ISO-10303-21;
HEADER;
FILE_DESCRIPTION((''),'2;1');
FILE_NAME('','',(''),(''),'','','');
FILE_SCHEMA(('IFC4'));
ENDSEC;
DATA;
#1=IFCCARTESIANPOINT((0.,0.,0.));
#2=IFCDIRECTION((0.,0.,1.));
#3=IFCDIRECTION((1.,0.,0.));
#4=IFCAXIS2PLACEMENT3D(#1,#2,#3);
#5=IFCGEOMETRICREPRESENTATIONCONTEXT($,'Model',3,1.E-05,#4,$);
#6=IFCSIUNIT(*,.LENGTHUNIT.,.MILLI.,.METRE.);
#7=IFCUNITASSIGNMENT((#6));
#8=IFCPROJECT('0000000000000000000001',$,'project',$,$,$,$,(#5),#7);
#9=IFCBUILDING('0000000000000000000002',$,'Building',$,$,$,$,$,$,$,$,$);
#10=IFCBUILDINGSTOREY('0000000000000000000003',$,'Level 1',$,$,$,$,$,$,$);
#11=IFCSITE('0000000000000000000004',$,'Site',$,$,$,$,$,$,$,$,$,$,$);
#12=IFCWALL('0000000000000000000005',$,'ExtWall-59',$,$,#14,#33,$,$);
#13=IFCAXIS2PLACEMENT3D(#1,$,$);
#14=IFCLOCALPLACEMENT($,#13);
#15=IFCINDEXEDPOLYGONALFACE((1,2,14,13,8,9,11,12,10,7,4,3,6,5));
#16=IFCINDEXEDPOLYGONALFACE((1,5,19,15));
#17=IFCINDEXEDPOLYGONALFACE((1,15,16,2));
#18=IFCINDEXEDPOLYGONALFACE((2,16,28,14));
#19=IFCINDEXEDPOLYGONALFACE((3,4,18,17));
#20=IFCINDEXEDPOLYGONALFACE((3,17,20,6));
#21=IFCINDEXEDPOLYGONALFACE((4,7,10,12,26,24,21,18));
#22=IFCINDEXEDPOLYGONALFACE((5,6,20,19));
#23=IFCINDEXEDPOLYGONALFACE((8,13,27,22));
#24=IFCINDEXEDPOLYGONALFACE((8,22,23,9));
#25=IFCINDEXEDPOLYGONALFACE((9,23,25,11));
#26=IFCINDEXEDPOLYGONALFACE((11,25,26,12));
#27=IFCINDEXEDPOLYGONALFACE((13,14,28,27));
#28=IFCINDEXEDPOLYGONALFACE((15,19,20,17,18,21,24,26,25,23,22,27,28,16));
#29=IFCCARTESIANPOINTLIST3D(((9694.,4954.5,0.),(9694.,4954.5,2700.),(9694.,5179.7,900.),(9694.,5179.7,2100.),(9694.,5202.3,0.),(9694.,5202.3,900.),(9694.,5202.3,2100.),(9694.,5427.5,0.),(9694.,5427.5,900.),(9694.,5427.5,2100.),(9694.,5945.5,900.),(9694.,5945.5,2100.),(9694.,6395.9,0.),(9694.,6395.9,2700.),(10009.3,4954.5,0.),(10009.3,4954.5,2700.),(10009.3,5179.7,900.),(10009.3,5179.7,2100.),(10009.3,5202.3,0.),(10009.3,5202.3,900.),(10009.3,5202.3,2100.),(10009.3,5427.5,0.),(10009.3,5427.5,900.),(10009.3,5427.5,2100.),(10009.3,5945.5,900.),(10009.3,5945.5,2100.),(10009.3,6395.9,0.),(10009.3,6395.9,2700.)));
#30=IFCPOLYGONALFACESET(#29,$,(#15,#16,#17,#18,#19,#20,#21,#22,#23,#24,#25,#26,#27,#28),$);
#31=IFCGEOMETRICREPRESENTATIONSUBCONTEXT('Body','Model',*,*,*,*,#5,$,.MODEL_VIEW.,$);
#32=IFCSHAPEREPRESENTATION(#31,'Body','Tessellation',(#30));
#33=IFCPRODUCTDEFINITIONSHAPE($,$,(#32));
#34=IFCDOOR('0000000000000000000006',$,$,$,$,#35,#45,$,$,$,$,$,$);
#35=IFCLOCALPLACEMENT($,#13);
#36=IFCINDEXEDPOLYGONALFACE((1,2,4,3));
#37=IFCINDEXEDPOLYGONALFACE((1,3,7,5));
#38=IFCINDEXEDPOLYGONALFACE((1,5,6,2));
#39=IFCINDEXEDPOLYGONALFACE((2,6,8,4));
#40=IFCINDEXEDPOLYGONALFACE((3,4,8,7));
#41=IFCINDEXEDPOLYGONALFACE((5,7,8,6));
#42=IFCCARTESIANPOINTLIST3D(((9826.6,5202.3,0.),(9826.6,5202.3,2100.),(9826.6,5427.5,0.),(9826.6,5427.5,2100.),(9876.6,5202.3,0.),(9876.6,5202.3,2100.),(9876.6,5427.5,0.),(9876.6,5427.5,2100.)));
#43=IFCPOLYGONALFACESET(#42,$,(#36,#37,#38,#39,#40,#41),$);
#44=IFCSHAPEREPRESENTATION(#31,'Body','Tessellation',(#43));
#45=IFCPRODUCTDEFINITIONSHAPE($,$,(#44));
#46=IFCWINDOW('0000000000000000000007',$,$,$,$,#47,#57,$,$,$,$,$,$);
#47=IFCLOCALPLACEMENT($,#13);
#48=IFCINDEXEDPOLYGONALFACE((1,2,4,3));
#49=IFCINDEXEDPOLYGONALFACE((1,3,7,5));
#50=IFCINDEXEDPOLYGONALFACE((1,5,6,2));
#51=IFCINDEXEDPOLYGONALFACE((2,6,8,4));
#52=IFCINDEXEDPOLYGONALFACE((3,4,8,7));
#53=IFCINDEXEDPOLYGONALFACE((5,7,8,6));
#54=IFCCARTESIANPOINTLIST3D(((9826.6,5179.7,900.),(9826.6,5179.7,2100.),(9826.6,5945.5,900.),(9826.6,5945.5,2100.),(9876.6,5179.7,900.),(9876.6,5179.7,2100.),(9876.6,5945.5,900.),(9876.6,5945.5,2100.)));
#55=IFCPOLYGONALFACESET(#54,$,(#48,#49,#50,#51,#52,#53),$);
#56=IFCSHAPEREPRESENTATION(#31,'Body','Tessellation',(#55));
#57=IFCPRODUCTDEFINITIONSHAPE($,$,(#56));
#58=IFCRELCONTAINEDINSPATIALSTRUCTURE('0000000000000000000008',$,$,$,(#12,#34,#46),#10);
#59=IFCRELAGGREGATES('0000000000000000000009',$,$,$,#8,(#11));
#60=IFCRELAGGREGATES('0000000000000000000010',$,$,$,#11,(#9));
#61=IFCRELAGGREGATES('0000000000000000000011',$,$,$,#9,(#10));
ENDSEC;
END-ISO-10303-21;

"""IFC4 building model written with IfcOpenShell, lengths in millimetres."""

from ifc_helpers import new_model, si_unit, frame, origin_with_axes, place, context, subcontext, project, spatial, indexed_curve, outline, extrude, element, fill, save


model = new_model("IFC4")

# Units and contexts
model_context = context("Model", 3, precision=1e-05, world=origin_with_axes())
body_context = subcontext(model_context, "Body", "Model", "MODEL_VIEW")
ifc_project = project(units=[si_unit("LENGTHUNIT", "METRE", prefix="MILLI")], contexts=[model_context])

# Site, building, storey
site = spatial("IfcSite", under=ifc_project, Name="Site")
building = spatial("IfcBuilding", under=site, Name="Building")
storey = spatial("IfcBuildingStorey", under=building, Name="Level 1")

# Wall, openings, door, window
wall_1_placement = place(None, frame((9851.6, 4954.5, 0.0), z_axis=(0.0, 0.0, 1.0), x_axis=(0.0, 1.0, 0.0)))
wall_1 = element("IfcWall", 1, at=wall_1_placement, inside=storey, Name="ExtWall-59", context=body_context, shape_type="SweptSolid", body=[
    extrude(outline(indexed_curve([(0.0, 0.0), (0.0, 315.3), (1441.3, 315.3), (1441.3, 0.0), (0.0, 0.0)], self_intersect=False)), frame((0.0, -157.6, 0.0), z_axis=(0.0, 0.0, 1.0), x_axis=(1.0, 0.0, 0.0)), (0.0, 0.0, 1.0), 2700.0),
])
opening_1_placement = place(wall_1_placement, frame((247.7, 0.0, 0.0), z_axis=(0.0, 0.0, 1.0), x_axis=(1.0, 0.0, 0.0)))
opening_1 = element("IfcOpeningElement", 2, at=opening_1_placement, cuts=wall_1, context=body_context, shape_type="SweptSolid", body=[
    extrude(outline(indexed_curve([(0.0, 0.0), (0.0, 415.3), (225.2, 415.3), (225.2, 0.0), (0.0, 0.0)], self_intersect=False)), frame((0.0, -207.6, 0.0), z_axis=(0.0, 0.0, 1.0), x_axis=(1.0, 0.0, 0.0)), (0.0, 0.0, 1.0), 2100.0),
])
opening_2_placement = place(wall_1_placement, frame((225.2, 0.0, 900.0), z_axis=(0.0, 0.0, 1.0), x_axis=(1.0, 0.0, 0.0)))
opening_2 = element("IfcOpeningElement", 3, at=opening_2_placement, cuts=wall_1, context=body_context, shape_type="SweptSolid", body=[
    extrude(outline(indexed_curve([(0.0, 0.0), (0.0, 415.3), (765.7, 415.3), (765.7, 0.0), (0.0, 0.0)], self_intersect=False)), frame((0.0, -207.6, 0.0), z_axis=(0.0, 0.0, 1.0), x_axis=(1.0, 0.0, 0.0)), (0.0, 0.0, 1.0), 1200.0),
])
door_1_placement = place(opening_1_placement, origin_with_axes())
door_1 = element("IfcDoor", 4, at=door_1_placement, inside=storey, context=body_context, shape_type="SweptSolid", body=[
    extrude(outline(indexed_curve([(0.0, 0.0), (0.0, 50.0), (225.2, 50.0), (225.2, 0.0), (0.0, 0.0)], self_intersect=False)), frame((0.0, -25.0, 0.0), z_axis=(0.0, 0.0, 1.0), x_axis=(1.0, 0.0, 0.0)), (0.0, 0.0, 1.0), 2100.0),
])
fill(opening_1, door_1)
window_1_placement = place(opening_2_placement, origin_with_axes())
window_1 = element("IfcWindow", 5, at=window_1_placement, inside=storey, context=body_context, shape_type="SweptSolid", body=[
    extrude(outline(indexed_curve([(0.0, 0.0), (0.0, 50.0), (765.7, 50.0), (765.7, 0.0), (0.0, 0.0)], self_intersect=False)), frame((0.0, -25.0, 0.0), z_axis=(0.0, 0.0, 1.0), x_axis=(1.0, 0.0, 0.0)), (0.0, 0.0, 1.0), 1200.0),
])
fill(opening_2, window_1)

save(model, "model.ifc")
